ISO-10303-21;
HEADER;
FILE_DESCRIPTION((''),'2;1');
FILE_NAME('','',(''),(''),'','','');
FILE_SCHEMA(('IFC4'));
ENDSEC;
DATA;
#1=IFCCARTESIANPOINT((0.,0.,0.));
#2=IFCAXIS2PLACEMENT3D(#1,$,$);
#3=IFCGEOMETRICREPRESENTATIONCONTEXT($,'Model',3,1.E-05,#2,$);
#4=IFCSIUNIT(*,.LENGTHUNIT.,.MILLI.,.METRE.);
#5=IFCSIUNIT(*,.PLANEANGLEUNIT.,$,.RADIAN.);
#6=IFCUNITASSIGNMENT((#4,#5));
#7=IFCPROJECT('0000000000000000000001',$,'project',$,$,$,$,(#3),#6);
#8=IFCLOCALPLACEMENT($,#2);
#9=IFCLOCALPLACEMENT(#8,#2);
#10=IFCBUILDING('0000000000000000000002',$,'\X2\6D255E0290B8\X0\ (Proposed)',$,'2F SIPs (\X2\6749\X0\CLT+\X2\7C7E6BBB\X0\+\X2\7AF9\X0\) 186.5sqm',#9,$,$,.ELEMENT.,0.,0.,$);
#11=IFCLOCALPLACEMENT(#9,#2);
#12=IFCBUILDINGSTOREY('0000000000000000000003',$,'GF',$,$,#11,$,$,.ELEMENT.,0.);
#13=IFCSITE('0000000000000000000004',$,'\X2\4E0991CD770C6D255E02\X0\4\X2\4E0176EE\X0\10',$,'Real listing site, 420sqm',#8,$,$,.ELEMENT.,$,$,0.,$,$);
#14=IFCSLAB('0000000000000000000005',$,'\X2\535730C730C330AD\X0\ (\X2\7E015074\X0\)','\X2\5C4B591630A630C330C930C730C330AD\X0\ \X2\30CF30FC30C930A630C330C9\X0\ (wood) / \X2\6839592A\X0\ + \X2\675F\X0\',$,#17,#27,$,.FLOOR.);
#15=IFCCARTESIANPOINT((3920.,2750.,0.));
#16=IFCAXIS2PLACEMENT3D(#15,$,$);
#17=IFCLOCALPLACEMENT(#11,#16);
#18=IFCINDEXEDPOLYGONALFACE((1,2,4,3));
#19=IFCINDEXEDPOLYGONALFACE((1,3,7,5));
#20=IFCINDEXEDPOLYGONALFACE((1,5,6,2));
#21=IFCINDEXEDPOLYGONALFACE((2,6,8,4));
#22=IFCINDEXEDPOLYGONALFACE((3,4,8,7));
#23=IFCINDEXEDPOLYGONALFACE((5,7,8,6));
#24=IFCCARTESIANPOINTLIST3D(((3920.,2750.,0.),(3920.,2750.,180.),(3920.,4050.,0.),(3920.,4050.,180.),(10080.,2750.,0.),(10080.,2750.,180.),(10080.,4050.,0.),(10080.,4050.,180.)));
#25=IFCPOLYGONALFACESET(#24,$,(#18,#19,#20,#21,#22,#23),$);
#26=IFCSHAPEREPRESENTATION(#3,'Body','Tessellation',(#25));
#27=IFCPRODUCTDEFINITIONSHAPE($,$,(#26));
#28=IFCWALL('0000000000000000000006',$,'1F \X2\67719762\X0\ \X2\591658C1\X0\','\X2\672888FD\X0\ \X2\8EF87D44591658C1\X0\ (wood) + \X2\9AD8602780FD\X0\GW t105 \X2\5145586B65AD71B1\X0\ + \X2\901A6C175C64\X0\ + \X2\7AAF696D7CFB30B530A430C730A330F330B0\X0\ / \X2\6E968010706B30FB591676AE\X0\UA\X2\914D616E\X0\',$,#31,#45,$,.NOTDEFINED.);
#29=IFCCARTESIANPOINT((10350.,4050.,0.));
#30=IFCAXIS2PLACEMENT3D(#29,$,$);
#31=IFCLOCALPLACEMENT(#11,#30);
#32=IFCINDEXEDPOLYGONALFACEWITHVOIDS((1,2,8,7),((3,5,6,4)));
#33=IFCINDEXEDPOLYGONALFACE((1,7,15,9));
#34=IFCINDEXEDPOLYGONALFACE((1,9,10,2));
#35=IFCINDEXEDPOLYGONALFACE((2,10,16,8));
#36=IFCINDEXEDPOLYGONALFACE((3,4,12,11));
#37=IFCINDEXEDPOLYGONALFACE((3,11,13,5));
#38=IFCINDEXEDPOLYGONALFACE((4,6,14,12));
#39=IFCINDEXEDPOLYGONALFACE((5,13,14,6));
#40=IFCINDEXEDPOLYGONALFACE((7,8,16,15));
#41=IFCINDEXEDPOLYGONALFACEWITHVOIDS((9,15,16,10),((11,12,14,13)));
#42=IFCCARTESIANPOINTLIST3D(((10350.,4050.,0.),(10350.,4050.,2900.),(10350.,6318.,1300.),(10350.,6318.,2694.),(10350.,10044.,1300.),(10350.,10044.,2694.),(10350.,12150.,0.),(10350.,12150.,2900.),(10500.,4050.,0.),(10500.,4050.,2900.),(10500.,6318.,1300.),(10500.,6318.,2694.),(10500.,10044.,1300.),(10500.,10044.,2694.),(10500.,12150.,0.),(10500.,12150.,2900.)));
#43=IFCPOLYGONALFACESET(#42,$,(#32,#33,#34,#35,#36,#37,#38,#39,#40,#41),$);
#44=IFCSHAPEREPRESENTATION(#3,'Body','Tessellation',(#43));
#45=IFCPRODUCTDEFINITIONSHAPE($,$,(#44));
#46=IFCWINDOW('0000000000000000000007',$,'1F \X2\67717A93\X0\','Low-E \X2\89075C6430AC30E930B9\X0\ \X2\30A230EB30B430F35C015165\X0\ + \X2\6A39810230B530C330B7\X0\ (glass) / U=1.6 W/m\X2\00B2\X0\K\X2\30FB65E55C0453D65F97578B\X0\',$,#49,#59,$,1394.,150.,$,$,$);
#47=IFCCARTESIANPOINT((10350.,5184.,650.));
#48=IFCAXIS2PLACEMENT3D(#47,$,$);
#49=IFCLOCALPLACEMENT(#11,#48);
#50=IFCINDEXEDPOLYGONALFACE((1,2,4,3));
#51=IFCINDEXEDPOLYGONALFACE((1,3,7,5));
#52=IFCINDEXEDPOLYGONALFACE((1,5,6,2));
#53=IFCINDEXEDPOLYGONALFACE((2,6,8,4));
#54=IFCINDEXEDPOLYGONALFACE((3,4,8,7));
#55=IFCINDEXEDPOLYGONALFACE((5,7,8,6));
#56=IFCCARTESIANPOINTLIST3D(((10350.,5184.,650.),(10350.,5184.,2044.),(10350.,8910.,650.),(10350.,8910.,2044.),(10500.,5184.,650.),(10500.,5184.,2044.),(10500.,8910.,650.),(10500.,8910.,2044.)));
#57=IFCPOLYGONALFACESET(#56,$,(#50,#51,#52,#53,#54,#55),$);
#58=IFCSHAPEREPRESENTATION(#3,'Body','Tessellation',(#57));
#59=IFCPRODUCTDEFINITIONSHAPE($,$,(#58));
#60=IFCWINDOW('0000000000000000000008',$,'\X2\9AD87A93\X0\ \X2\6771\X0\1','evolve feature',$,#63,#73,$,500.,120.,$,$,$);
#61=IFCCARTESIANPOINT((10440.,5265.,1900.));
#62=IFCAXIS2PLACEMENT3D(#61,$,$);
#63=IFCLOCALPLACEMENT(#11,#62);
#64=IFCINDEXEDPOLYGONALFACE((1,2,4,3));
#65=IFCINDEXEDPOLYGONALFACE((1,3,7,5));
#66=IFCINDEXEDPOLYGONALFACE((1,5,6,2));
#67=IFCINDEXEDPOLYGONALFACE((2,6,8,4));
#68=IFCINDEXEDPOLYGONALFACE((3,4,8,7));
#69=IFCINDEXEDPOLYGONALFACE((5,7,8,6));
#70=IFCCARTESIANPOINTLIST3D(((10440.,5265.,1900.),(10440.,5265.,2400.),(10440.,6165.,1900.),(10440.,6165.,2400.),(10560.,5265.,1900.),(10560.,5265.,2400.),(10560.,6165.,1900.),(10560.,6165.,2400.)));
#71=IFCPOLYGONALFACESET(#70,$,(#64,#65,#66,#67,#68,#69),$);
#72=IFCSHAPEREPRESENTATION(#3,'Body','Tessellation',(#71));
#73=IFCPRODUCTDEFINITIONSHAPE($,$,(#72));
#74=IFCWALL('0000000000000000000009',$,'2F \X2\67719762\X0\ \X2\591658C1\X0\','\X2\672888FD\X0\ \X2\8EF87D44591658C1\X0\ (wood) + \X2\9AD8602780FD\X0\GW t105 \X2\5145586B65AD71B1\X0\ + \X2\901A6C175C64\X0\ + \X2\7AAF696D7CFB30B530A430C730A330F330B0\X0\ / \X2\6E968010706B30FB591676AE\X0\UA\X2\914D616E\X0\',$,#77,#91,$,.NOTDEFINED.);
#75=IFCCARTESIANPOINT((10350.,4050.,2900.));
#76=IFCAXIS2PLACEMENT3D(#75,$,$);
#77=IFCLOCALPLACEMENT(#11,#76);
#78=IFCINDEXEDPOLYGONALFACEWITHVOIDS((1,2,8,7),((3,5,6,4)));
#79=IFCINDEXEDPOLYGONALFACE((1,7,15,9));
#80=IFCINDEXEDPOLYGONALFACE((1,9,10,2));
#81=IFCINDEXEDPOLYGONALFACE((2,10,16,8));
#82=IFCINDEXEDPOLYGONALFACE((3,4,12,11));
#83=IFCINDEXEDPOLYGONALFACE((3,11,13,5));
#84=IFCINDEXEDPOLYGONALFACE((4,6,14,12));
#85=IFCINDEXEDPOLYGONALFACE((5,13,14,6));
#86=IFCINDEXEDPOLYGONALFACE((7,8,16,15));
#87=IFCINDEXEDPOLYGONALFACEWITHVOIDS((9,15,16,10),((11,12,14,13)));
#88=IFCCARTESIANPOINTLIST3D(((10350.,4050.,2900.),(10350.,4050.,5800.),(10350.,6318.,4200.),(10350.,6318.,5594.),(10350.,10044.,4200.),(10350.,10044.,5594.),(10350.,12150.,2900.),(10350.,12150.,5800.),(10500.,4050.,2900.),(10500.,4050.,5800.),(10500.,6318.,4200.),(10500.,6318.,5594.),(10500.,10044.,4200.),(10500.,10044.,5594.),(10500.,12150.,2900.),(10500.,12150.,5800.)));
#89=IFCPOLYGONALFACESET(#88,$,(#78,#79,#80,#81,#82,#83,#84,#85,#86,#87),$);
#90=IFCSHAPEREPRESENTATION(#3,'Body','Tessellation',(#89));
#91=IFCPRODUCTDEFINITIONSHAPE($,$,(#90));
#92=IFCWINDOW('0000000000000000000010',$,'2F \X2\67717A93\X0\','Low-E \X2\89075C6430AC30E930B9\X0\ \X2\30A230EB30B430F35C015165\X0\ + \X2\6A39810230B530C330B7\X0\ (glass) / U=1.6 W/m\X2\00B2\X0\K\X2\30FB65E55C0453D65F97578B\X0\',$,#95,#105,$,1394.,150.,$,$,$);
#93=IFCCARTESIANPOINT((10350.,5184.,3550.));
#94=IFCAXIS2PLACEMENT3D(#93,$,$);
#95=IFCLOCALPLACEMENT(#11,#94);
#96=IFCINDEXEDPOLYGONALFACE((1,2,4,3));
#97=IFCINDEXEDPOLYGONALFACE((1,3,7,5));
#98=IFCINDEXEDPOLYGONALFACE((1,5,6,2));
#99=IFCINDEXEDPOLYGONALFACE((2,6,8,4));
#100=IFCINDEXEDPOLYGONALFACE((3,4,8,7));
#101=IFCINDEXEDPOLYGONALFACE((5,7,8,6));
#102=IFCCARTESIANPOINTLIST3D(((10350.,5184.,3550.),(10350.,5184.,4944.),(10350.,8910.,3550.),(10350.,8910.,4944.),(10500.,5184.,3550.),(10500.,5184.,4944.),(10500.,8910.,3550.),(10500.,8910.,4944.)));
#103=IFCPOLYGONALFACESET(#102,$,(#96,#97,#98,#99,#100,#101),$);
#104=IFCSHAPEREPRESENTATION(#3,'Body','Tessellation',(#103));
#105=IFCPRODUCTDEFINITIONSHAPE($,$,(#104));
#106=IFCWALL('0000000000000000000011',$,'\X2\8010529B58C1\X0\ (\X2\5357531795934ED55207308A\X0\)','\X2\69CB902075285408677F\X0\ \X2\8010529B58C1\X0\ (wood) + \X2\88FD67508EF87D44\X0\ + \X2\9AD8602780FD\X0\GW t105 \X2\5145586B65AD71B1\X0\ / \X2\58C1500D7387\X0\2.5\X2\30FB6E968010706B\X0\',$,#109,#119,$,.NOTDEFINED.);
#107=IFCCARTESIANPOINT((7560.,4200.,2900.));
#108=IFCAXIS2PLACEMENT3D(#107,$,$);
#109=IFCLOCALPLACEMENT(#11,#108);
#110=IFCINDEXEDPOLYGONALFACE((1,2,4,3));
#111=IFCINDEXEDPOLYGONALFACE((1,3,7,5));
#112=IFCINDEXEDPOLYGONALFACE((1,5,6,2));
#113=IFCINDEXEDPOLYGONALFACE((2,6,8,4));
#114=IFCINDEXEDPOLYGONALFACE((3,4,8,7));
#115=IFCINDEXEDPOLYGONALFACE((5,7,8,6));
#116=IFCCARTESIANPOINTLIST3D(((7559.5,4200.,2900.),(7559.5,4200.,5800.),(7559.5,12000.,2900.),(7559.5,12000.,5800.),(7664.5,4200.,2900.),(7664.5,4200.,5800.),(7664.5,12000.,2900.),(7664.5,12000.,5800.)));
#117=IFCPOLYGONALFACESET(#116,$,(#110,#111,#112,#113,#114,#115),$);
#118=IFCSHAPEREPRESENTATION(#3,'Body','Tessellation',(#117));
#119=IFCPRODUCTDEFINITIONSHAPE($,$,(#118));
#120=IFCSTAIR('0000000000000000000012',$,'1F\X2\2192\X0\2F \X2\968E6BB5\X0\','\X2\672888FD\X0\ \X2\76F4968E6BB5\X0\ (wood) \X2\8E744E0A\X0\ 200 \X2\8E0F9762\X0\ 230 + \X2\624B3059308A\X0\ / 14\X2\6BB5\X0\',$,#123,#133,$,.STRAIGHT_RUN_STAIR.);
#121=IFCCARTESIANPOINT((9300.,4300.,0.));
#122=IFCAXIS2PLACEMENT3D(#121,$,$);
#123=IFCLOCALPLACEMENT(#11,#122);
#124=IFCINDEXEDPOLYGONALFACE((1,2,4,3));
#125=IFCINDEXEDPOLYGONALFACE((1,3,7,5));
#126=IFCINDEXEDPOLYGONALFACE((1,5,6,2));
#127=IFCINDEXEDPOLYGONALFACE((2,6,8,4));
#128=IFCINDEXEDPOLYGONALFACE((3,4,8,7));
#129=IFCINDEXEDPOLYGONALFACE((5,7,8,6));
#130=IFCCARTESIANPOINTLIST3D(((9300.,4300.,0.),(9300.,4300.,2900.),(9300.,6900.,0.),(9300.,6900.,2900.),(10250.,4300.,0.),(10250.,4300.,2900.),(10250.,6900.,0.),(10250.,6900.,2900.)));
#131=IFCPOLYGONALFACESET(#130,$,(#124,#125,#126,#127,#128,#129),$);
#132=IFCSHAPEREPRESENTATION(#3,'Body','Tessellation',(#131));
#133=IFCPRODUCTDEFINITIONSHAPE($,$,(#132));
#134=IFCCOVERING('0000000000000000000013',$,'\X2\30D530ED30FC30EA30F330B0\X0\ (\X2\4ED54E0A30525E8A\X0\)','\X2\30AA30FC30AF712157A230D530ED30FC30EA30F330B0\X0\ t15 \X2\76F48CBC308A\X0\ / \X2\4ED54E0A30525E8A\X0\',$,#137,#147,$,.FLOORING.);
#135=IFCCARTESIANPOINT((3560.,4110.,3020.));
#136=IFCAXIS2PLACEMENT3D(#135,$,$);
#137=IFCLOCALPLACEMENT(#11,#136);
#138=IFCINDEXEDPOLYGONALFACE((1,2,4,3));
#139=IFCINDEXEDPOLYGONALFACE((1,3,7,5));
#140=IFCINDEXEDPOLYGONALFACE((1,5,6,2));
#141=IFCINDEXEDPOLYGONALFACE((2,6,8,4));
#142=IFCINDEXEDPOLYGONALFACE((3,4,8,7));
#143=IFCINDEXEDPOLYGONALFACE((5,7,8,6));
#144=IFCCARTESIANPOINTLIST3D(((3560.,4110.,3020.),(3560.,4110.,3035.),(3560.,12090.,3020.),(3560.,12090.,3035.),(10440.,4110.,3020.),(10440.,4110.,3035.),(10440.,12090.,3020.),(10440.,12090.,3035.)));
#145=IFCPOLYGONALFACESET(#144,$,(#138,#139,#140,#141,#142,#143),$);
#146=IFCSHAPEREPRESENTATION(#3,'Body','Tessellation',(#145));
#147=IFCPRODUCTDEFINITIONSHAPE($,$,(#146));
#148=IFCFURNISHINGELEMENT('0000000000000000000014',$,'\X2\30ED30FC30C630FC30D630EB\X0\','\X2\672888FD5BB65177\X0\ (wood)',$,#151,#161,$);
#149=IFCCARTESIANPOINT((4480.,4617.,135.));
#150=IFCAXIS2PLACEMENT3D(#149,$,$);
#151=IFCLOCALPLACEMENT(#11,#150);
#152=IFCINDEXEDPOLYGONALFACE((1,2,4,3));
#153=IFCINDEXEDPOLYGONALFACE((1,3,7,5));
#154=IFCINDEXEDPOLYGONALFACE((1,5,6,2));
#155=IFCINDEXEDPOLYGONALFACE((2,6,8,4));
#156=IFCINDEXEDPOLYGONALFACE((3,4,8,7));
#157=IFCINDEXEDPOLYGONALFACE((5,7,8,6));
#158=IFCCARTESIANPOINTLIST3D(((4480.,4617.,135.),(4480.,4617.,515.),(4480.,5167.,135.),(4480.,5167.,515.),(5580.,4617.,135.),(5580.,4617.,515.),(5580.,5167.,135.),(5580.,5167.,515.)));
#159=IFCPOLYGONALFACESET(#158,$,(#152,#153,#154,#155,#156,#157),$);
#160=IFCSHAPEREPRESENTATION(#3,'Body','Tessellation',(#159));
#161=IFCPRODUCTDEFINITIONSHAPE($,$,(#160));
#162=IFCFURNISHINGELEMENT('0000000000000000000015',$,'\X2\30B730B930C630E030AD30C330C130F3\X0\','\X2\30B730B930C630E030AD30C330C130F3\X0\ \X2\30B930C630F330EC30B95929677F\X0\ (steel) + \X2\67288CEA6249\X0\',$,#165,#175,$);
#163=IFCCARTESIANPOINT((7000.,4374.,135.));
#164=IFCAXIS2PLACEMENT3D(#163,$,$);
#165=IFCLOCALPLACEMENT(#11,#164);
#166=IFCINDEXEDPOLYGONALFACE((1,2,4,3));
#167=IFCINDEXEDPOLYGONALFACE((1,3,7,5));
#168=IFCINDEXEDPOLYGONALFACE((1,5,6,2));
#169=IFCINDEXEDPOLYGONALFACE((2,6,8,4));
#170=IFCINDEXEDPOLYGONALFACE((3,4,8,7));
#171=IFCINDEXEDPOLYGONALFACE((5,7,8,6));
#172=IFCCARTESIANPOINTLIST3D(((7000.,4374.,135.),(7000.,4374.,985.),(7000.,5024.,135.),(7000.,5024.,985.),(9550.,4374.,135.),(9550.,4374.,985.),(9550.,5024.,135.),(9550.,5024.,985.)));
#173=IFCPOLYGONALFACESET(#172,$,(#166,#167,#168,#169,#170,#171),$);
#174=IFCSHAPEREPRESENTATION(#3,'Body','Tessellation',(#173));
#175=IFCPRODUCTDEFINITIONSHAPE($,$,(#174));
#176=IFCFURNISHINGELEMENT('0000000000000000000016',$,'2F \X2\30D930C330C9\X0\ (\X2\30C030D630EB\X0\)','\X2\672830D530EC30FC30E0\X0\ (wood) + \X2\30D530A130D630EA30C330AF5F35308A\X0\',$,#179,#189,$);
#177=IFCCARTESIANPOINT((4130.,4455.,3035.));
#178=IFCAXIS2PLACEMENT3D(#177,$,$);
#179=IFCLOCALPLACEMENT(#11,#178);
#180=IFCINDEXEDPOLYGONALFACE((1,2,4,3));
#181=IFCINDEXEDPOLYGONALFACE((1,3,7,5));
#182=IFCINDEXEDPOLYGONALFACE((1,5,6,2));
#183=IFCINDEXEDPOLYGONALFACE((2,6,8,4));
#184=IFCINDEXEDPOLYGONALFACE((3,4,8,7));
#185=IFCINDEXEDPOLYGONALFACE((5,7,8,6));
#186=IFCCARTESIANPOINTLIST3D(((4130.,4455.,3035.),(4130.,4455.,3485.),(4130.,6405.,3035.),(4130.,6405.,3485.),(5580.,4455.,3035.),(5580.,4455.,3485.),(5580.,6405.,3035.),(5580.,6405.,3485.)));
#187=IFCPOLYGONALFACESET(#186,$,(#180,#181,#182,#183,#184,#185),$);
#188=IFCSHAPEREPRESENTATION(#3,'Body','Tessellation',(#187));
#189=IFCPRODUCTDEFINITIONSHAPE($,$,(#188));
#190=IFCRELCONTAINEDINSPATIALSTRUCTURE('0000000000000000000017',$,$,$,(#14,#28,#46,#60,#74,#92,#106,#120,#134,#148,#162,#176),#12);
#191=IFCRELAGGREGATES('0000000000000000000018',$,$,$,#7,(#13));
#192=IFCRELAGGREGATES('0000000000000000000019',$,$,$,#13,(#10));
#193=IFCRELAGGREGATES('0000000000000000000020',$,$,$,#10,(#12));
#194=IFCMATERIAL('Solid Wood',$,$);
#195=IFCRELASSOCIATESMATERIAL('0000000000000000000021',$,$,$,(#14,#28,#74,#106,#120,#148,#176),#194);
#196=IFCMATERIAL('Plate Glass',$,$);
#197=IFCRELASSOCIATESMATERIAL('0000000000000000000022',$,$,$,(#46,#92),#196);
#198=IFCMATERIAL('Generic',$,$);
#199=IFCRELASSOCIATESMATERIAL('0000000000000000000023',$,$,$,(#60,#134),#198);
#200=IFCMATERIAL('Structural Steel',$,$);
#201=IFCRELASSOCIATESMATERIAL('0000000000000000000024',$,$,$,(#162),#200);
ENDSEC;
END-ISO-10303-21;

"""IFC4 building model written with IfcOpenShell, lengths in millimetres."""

from ifc_helpers import new_model, si_unit, frame, frame_2d, origin, place, context, project, spatial, rectangle, extrude, material, element, fill, save


model = new_model("IFC4")

# Units and contexts
model_context = context("Model", 3, precision=1e-05, world=origin())
ifc_project = project(units=[si_unit("LENGTHUNIT", "METRE", prefix="MILLI"), si_unit("PLANEANGLEUNIT", "RADIAN")], contexts=[model_context])

# Site, building, storey
site_placement = place(None, origin())
site = spatial("IfcSite", under=ifc_project, at=site_placement, Name="三重県津市4丁目10", ObjectType="Real listing site, 420sqm", CompositionType="ELEMENT", RefElevation=0.0)
building_placement = place(site_placement, origin())
building = spatial("IfcBuilding", under=site, at=building_placement, Name="津市邸 (Proposed)", ObjectType="2F SIPs (杉CLT+籾殻+竹) 186.5sqm", CompositionType="ELEMENT", ElevationOfRefHeight=0.0, ElevationOfTerrain=0.0)
storey_placement = place(building_placement, origin())
storey = spatial("IfcBuildingStorey", under=building, at=storey_placement, Name="GF", CompositionType="ELEMENT", Elevation=0.0)

# Slab
ifc_material_1 = material(Name="Solid Wood")
slab_placement = place(storey_placement, frame((3920.0, 2750.0, 0.0)))
element("IfcSlab", 1, at=slab_placement, inside=storey, material=ifc_material_1, Name="南デッキ (縁側)", Description="屋外ウッドデッキ ハードウッド (wood) / 根太 + 束", PredefinedType="FLOOR", context=model_context, shape_type="SweptSolid", body=[
    extrude(rectangle(XDim=6160.0, YDim=1300.0, at=frame_2d((3080.0, 650.0))), frame((3920.0, 2750.0, 0.0)), (0.0, 0.0, 1.0), 180.0),
])

# Wall, openings, windows
wall_1_placement = place(storey_placement, frame((10350.0, 4050.0, 0.0)))
wall_1 = element("IfcWall", 2, at=wall_1_placement, inside=storey, material=ifc_material_1, Name="1F 東面 外壁", Description="木製 軸組外壁 (wood) + 高性能GW t105 充填断熱 + 通気層 + 窯業系サイディング / 準耐火・外皮UA配慮", PredefinedType="NOTDEFINED", context=model_context, shape_type="SweptSolid", body=[
    extrude(rectangle(XDim=150.0, YDim=8100.0, at=frame_2d((75.0, 4050.0))), frame((10350.0, 4050.0, 0.0)), (0.0, 0.0, 1.0), 2900.0),
])
opening_1_placement = place(storey_placement, frame((10350.0, 5184.0, 650.0)))
opening_1 = element("IfcOpeningElement", 3, at=opening_1_placement, cuts=wall_1, PredefinedType="NOTDEFINED", context=model_context, shape_type="SweptSolid", body=[
    extrude(rectangle(XDim=150.0, YDim=3726.0, at=frame_2d((75.0, 1863.0))), frame((10350.0, 5184.0, 650.0)), (0.0, 0.0, 1.0), 1394.0),
])
opening_2_placement = place(storey_placement, frame((10440.0, 5265.0, 1900.0)))
opening_2 = element("IfcOpeningElement", 4, at=opening_2_placement, cuts=wall_1, PredefinedType="NOTDEFINED", context=model_context, shape_type="SweptSolid", body=[
    extrude(rectangle(XDim=120.0, YDim=900.0, at=frame_2d((60.0, 450.0))), frame((10440.0, 5265.0, 1900.0)), (0.0, 0.0, 1.0), 500.0),
])
ifc_material_2 = material(Name="Plate Glass")
window_1_placement = place(storey_placement, frame((10350.0, 5184.0, 650.0)))
window_1 = element("IfcWindow", 5, at=window_1_placement, inside=storey, material=ifc_material_2, Name="1F 東窓", Description="Low-E 複層ガラス アルゴン封入 + 樹脂サッシ (glass) / U=1.6 W/m²K・日射取得型", OverallHeight=1394.0, OverallWidth=150.0, context=model_context, shape_type="SweptSolid", body=[
    extrude(rectangle(XDim=150.0, YDim=3726.0, at=frame_2d((75.0, 1863.0))), frame((10350.0, 5184.0, 650.0)), (0.0, 0.0, 1.0), 1394.0),
])
fill(opening_1, window_1)
ifc_material_3 = material(Name="Generic")
window_2_placement = place(storey_placement, frame((10440.0, 5265.0, 1900.0)))
window_2 = element("IfcWindow", 6, at=window_2_placement, inside=storey, material=ifc_material_3, Name="高窓 東1", Description="evolve feature", OverallHeight=500.0, OverallWidth=120.0, context=model_context, shape_type="SweptSolid", body=[
    extrude(rectangle(XDim=120.0, YDim=900.0, at=frame_2d((60.0, 450.0))), frame((10440.0, 5265.0, 1900.0)), (0.0, 0.0, 1.0), 500.0),
])
fill(opening_2, window_2)

# Wall, opening, window
wall_2_placement = place(storey_placement, frame((10350.0, 4050.0, 2900.0)))
wall_2 = element("IfcWall", 7, at=wall_2_placement, inside=storey, material=ifc_material_1, Name="2F 東面 外壁", Description="木製 軸組外壁 (wood) + 高性能GW t105 充填断熱 + 通気層 + 窯業系サイディング / 準耐火・外皮UA配慮", PredefinedType="NOTDEFINED", context=model_context, shape_type="SweptSolid", body=[
    extrude(rectangle(XDim=150.0, YDim=8100.0, at=frame_2d((75.0, 4050.0))), frame((10350.0, 4050.0, 2900.0)), (0.0, 0.0, 1.0), 2900.0),
])
opening_3_placement = place(storey_placement, frame((10350.0, 5184.0, 3550.0)))
opening_3 = element("IfcOpeningElement", 8, at=opening_3_placement, cuts=wall_2, PredefinedType="NOTDEFINED", context=model_context, shape_type="SweptSolid", body=[
    extrude(rectangle(XDim=150.0, YDim=3726.0, at=frame_2d((75.0, 1863.0))), frame((10350.0, 5184.0, 3550.0)), (0.0, 0.0, 1.0), 1394.0),
])
window_3_placement = place(storey_placement, frame((10350.0, 5184.0, 3550.0)))
window_3 = element("IfcWindow", 9, at=window_3_placement, inside=storey, material=ifc_material_2, Name="2F 東窓", Description="Low-E 複層ガラス アルゴン封入 + 樹脂サッシ (glass) / U=1.6 W/m²K・日射取得型", OverallHeight=1394.0, OverallWidth=150.0, context=model_context, shape_type="SweptSolid", body=[
    extrude(rectangle(XDim=150.0, YDim=3726.0, at=frame_2d((75.0, 1863.0))), frame((10350.0, 5184.0, 3550.0)), (0.0, 0.0, 1.0), 1394.0),
])
fill(opening_3, window_3)

# Wall
wall_3_placement = place(storey_placement, frame((7560.0, 4200.0, 2900.0)))
element("IfcWall", 10, at=wall_3_placement, inside=storey, material=ifc_material_1, Name="耐力壁 (南北間仕切り)", Description="構造用合板 耐力壁 (wood) + 製材軸組 + 高性能GW t105 充填断熱 / 壁倍率2.5・準耐火", PredefinedType="NOTDEFINED", context=model_context, shape_type="SweptSolid", body=[
    extrude(rectangle(XDim=105.0, YDim=7800.0, at=frame_2d((52.0, 3900.0))), frame((7560.0, 4200.0, 2900.0)), (0.0, 0.0, 1.0), 2900.0),
])

# Stair
stair_placement = place(storey_placement, frame((9300.0, 4300.0, 0.0)))
element("IfcStair", 11, at=stair_placement, inside=storey, material=ifc_material_1, Name="1F→2F 階段", Description="木製 直階段 (wood) 蹴上 200 踏面 230 + 手すり / 14段", PredefinedType="STRAIGHT_RUN_STAIR", context=model_context, shape_type="SweptSolid", body=[
    extrude(rectangle(XDim=950.0, YDim=2600.0, at=frame_2d((475.0, 1300.0))), frame((9300.0, 4300.0, 0.0)), (0.0, 0.0, 1.0), 2900.0),
])

# Covering
covering_placement = place(storey_placement, frame((3560.0, 4110.0, 3020.0)))
element("IfcCovering", 12, at=covering_placement, inside=storey, material=ifc_material_3, Name="フローリング (仕上げ床)", Description="オーク無垢フローリング t15 直貼り / 仕上げ床", PredefinedType="FLOORING", context=model_context, shape_type="SweptSolid", body=[
    extrude(rectangle(XDim=6880.0, YDim=7980.0, at=frame_2d((3440.0, 3990.0))), frame((3560.0, 4110.0, 3020.0)), (0.0, 0.0, 1.0), 15.0),
])

# Furnishing elements
furnishing_1_placement = place(storey_placement, frame((4480.0, 4617.0, 135.0)))
element("IfcFurnishingElement", 13, at=furnishing_1_placement, inside=storey, material=ifc_material_1, Name="ローテーブル", Description="木製家具 (wood)", context=model_context, shape_type="SweptSolid", body=[
    extrude(rectangle(XDim=1100.0, YDim=550.0, at=frame_2d((550.0, 275.0))), frame((4480.0, 4617.0, 135.0)), (0.0, 0.0, 1.0), 380.0),
])
ifc_material_4 = material(Name="Structural Steel")
furnishing_2_placement = place(storey_placement, frame((7000.0, 4374.0, 135.0)))
element("IfcFurnishingElement", 14, at=furnishing_2_placement, inside=storey, material=ifc_material_4, Name="システムキッチン", Description="システムキッチン ステンレス天板 (steel) + 木質扉", context=model_context, shape_type="SweptSolid", body=[
    extrude(rectangle(XDim=2550.0, YDim=650.0, at=frame_2d((1275.0, 325.0))), frame((7000.0, 4374.0, 135.0)), (0.0, 0.0, 1.0), 850.0),
])
furnishing_3_placement = place(storey_placement, frame((4130.0, 4455.0, 3035.0)))
element("IfcFurnishingElement", 15, at=furnishing_3_placement, inside=storey, material=ifc_material_1, Name="2F ベッド (ダブル)", Description="木フレーム (wood) + ファブリック張り", context=model_context, shape_type="SweptSolid", body=[
    extrude(rectangle(XDim=1450.0, YDim=1950.0, at=frame_2d((725.0, 975.0))), frame((4130.0, 4455.0, 3035.0)), (0.0, 0.0, 1.0), 450.0),
])

save(model, "model.ifc")
